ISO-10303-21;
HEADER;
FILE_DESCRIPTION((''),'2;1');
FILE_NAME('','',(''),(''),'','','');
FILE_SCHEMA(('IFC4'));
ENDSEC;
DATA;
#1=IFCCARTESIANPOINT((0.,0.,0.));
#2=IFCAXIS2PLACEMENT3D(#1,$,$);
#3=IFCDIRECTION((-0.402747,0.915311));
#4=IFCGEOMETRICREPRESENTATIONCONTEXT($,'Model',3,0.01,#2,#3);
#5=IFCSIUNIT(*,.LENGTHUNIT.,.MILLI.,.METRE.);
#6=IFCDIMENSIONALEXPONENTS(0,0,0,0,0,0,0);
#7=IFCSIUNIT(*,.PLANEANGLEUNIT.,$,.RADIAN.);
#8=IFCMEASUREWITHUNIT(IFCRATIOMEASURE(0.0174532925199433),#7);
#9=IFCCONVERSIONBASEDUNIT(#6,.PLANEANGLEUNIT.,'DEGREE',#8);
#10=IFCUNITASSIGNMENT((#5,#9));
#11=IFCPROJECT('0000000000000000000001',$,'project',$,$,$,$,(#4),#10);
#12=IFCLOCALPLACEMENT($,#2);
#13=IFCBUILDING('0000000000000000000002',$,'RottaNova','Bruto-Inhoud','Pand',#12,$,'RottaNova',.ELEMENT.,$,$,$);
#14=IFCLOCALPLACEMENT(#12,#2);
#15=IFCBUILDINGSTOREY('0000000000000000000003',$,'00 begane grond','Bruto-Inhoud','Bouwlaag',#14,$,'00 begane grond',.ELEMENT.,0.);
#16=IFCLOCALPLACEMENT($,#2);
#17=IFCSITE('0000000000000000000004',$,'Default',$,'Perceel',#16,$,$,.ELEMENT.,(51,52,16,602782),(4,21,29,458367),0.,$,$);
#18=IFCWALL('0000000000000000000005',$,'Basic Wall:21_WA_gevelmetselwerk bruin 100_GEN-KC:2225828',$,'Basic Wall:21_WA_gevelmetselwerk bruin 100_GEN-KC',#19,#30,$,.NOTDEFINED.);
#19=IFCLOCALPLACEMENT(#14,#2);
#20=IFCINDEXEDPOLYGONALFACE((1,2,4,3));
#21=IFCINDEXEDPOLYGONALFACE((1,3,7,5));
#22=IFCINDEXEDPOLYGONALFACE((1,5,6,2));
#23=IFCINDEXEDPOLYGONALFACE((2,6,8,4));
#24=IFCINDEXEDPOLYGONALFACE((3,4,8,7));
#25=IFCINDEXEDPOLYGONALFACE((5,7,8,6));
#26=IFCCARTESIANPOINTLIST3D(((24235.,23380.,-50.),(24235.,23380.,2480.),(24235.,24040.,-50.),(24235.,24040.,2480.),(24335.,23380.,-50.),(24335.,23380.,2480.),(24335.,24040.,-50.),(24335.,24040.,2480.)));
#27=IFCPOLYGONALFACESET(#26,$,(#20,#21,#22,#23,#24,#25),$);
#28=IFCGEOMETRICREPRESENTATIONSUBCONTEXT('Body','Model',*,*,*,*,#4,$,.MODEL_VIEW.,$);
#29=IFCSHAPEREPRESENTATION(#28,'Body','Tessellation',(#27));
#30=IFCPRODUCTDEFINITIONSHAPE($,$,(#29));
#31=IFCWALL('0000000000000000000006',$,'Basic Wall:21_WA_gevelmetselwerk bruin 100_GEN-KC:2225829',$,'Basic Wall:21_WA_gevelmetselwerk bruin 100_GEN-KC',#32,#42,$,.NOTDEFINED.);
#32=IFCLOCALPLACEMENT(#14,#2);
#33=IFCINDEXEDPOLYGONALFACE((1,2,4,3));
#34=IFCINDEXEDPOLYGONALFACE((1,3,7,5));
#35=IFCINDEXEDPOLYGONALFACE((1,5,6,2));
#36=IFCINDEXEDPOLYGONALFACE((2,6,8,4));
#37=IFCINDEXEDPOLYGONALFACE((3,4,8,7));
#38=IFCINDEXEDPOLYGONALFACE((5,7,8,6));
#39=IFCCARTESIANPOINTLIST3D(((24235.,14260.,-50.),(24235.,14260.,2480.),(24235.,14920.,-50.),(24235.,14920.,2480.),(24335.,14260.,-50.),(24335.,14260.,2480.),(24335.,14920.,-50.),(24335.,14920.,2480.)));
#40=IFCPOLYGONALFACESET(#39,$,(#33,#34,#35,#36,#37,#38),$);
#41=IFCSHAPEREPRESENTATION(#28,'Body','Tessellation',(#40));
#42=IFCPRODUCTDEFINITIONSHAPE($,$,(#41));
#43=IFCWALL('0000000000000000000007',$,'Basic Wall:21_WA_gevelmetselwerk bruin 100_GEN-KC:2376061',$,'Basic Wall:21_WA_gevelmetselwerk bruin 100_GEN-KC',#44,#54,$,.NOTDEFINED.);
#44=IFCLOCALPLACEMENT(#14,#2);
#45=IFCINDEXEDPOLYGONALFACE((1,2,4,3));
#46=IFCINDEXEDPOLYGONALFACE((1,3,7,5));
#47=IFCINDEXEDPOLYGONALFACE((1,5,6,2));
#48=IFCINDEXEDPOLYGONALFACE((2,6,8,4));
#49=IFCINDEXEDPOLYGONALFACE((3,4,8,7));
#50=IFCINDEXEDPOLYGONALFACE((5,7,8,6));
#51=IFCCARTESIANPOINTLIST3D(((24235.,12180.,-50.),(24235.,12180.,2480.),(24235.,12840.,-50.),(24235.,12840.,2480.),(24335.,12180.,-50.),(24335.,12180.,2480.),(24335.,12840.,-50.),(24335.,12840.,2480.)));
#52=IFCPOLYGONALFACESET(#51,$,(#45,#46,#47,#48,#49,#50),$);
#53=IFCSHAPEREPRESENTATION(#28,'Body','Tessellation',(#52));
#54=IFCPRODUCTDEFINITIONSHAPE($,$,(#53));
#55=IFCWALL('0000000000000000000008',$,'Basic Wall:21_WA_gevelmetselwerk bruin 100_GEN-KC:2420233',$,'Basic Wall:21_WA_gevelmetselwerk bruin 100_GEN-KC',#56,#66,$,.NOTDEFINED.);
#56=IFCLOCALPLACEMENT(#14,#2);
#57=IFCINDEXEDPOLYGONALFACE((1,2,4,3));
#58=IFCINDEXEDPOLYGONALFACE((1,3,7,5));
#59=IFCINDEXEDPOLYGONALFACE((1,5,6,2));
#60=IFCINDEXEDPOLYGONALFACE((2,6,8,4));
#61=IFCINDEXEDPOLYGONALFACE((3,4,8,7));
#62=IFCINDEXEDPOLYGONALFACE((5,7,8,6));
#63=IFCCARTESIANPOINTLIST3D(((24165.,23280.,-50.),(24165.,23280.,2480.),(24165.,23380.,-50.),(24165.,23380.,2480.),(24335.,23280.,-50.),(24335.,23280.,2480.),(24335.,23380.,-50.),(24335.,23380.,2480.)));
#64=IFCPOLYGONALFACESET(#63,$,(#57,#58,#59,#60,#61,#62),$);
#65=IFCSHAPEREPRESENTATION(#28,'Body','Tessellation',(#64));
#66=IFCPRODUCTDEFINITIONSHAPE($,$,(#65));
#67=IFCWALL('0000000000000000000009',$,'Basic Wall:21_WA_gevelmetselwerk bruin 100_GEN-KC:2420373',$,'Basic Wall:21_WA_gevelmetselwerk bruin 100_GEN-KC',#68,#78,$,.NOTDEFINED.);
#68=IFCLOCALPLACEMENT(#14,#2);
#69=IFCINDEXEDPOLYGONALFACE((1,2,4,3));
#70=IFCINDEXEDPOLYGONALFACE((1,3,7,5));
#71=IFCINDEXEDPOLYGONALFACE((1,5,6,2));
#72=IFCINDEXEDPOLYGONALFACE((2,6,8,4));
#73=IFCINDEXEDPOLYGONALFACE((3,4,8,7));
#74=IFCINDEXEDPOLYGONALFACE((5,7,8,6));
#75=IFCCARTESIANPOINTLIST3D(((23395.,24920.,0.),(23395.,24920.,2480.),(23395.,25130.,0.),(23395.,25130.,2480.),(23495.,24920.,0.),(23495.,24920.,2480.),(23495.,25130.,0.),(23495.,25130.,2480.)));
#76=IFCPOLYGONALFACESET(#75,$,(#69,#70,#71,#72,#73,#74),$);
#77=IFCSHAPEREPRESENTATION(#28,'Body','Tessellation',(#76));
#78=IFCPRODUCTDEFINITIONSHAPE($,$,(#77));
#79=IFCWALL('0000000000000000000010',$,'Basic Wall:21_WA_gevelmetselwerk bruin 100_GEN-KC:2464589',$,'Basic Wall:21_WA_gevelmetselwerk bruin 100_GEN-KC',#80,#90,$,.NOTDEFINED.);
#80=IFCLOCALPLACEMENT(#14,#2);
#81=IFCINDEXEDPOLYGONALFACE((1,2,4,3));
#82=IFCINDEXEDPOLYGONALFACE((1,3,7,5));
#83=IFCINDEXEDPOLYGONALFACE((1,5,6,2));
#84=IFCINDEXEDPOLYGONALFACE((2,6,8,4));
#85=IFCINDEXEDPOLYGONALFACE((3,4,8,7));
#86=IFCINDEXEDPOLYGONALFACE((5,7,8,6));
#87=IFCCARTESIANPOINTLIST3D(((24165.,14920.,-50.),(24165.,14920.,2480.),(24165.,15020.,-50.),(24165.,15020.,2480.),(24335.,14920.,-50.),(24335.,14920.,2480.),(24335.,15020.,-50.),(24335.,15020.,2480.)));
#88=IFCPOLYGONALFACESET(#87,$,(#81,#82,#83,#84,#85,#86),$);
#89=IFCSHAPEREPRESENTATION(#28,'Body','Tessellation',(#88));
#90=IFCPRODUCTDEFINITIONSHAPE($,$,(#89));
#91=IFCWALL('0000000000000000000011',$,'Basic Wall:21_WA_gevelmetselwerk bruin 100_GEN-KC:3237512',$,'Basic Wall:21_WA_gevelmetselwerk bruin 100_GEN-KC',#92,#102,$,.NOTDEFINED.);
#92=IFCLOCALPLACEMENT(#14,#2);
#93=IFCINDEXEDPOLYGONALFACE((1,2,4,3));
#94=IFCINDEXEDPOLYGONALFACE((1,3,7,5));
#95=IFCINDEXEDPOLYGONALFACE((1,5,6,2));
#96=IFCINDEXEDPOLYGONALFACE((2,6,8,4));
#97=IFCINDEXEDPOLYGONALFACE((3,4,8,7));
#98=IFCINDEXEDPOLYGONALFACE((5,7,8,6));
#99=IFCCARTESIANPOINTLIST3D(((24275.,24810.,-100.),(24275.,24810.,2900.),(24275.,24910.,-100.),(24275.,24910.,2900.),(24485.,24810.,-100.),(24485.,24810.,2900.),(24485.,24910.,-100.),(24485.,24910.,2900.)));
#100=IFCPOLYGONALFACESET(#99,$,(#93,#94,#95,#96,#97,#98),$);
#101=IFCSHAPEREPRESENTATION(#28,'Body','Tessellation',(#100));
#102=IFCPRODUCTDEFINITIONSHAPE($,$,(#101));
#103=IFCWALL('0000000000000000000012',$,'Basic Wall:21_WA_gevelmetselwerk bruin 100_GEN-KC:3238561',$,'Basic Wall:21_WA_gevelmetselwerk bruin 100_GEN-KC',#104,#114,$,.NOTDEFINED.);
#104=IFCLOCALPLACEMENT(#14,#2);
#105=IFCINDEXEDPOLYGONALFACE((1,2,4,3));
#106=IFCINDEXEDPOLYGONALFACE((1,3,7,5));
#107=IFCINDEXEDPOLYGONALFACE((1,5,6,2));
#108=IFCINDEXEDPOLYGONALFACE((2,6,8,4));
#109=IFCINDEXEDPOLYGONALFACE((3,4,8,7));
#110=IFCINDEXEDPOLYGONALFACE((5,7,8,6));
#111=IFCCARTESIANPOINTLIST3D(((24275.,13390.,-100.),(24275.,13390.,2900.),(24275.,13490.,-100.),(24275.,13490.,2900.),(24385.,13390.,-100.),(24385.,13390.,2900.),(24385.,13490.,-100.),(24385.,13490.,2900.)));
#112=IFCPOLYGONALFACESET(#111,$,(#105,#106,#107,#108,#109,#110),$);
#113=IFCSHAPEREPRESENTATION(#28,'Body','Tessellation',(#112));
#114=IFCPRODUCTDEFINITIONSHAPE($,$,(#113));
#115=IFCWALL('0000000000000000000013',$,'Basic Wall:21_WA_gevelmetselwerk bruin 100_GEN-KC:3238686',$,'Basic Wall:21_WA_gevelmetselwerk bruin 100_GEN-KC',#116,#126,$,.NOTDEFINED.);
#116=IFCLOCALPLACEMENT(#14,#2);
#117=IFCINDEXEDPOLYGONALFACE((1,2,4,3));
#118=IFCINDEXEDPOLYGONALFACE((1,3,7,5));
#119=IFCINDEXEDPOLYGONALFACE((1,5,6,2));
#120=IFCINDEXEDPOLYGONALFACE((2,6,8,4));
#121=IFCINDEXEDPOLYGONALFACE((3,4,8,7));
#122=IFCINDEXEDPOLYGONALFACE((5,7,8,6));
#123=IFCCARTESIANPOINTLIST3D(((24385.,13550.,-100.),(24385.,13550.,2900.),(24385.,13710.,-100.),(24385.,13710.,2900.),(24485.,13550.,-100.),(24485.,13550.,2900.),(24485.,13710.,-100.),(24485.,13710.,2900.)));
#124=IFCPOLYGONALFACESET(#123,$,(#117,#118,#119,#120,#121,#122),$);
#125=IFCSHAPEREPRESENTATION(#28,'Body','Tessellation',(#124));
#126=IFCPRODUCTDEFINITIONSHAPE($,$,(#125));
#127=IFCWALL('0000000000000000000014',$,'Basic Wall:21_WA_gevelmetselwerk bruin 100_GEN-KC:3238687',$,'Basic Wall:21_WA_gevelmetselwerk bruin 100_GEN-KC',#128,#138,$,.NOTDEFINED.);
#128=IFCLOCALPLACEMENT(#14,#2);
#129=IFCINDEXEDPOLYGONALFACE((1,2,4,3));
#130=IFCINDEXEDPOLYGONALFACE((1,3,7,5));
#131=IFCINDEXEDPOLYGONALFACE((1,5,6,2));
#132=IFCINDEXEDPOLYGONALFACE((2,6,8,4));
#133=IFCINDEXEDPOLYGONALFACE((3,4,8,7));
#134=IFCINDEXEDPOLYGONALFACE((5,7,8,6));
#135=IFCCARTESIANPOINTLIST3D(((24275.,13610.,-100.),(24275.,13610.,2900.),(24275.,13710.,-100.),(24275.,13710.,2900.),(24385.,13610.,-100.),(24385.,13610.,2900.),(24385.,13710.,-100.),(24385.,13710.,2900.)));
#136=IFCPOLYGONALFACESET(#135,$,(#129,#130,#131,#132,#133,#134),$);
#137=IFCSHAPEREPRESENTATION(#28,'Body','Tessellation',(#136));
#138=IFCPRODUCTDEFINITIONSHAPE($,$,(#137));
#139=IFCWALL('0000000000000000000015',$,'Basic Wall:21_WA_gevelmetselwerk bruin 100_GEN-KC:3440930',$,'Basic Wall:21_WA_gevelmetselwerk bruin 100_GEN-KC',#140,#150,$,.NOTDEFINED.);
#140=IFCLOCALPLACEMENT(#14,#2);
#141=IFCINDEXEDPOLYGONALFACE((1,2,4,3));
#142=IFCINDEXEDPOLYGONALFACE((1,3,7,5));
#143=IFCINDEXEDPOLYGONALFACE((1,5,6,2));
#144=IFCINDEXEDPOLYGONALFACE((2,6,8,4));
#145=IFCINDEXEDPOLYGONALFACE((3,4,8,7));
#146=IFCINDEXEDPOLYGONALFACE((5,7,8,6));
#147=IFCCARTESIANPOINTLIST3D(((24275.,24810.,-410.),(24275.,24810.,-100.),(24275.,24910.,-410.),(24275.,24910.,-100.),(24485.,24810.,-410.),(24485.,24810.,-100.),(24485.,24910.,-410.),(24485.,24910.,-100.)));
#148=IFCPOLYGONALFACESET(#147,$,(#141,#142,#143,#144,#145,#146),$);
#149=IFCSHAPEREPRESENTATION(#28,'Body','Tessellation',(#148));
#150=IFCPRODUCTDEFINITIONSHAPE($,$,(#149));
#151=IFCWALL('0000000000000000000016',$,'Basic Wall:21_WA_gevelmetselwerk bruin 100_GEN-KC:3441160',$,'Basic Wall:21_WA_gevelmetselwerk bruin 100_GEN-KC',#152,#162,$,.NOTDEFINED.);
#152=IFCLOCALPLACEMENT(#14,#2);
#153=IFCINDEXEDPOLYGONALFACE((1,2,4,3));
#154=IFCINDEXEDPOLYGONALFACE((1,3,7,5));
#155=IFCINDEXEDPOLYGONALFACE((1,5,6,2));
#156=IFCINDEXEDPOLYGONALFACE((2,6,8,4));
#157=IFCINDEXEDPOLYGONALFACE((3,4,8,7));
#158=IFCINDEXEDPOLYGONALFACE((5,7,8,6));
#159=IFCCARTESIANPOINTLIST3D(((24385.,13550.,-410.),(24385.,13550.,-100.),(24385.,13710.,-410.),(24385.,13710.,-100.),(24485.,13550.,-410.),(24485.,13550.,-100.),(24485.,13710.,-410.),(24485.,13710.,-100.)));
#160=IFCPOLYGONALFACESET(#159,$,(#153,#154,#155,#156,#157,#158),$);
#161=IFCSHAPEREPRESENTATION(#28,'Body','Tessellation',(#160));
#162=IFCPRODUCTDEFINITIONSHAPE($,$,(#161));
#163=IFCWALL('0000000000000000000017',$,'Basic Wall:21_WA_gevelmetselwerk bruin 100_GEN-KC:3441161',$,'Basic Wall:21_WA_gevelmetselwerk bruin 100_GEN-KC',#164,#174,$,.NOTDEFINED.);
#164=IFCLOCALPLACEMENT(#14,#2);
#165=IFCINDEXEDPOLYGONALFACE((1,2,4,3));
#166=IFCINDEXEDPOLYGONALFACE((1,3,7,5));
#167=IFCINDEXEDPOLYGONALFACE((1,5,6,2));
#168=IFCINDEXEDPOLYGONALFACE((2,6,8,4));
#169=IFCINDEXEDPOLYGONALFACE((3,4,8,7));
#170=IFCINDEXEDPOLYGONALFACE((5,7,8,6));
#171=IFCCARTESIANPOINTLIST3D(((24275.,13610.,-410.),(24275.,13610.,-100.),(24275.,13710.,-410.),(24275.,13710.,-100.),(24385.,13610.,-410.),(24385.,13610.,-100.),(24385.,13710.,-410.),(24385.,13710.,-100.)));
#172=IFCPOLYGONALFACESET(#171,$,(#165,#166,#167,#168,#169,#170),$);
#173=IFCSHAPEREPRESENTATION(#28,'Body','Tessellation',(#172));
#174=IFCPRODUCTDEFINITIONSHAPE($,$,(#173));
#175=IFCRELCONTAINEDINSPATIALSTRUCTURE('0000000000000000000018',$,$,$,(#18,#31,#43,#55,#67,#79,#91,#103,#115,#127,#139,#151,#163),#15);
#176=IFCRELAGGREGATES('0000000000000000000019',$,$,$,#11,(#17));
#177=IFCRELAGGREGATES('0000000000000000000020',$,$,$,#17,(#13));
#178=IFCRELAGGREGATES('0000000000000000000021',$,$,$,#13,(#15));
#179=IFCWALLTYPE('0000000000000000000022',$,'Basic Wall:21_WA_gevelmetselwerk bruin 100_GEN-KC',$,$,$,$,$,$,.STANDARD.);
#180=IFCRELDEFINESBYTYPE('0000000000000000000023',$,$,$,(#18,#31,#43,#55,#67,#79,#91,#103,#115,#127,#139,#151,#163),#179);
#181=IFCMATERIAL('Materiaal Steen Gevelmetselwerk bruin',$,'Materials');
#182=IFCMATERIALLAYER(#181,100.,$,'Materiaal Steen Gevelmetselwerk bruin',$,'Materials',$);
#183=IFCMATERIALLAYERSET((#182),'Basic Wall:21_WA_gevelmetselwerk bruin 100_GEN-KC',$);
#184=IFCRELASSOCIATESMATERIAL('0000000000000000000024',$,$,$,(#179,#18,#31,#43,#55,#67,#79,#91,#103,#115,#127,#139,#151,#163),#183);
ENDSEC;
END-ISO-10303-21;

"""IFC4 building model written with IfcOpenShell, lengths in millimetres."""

from ifc_helpers import new_model, entity, si_unit, converted_unit, direction, frame, frame_2d, origin, place, context, subcontext, project, spatial, rectangle, extrude, material, layer, layer_set, type_object, element, save


model = new_model("IFC4")

# Units and contexts
model_context = context("Model", 3, precision=0.01, world=origin(), true_north=direction((-0.402747, 0.915311)))
body_context = subcontext(model_context, "Body", "Model", "MODEL_VIEW")
ifc_project = project(units=[si_unit("LENGTHUNIT", "METRE", prefix="MILLI"), converted_unit("PLANEANGLEUNIT", "DEGREE", entity("IfcRatioMeasure", 0.0174532925199433), si_unit("PLANEANGLEUNIT", "RADIAN"), dimensions=[0, 0, 0, 0, 0, 0, 0])], contexts=[model_context])

# Site, building, storey
site_placement = place(None, origin())
site = spatial("IfcSite", under=ifc_project, at=site_placement, Name="Default", ObjectType="Perceel", CompositionType="ELEMENT", RefLatitude=(51, 52, 16, 602782), RefLongitude=(4, 21, 29, 458367), RefElevation=0.0)
building_placement = place(None, origin())
building = spatial("IfcBuilding", under=site, at=building_placement, Name="RottaNova", Description="Bruto-Inhoud", ObjectType="Pand", LongName="RottaNova", CompositionType="ELEMENT")
storey_placement = place(building_placement, origin())
storey = spatial("IfcBuildingStorey", under=building, at=storey_placement, Name="00 begane grond", Description="Bruto-Inhoud", ObjectType="Bouwlaag", LongName="00 begane grond", CompositionType="ELEMENT", Elevation=0.0)

# Walls
ifc_material_1 = material(Name="Materiaal Steen Gevelmetselwerk bruin", Category="Materials")
ifc_layer_1 = layer(ifc_material_1, 100.0, Name="Materiaal Steen Gevelmetselwerk bruin", Category="Materials")
ifc_layer_set_1 = layer_set([ifc_layer_1], Name="Basic Wall:21_WA_gevelmetselwerk bruin 100_GEN-KC")
wall_type_1 = type_object("IfcWallType", Name="Basic Wall:21_WA_gevelmetselwerk bruin 100_GEN-KC", PredefinedType="STANDARD", material=ifc_layer_set_1)
wall_1_placement = place(storey_placement, frame((24285.0, 24040.0, -50.0), z_axis=(0.0, 0.0, 1.0), x_axis=(0.0, -1.0, 0.0)))
element("IfcWall", 1, at=wall_1_placement, inside=storey, type_object=wall_type_1, material=ifc_layer_set_1, Name="Basic Wall:21_WA_gevelmetselwerk bruin 100_GEN-KC:2225828", ObjectType="Basic Wall:21_WA_gevelmetselwerk bruin 100_GEN-KC", PredefinedType="NOTDEFINED", context=body_context, shape_type="SweptSolid", body=[
    extrude(rectangle(XDim=660.0, YDim=100.0, at=frame_2d((330.0, 0.0), x_axis=(-1.0, 0.0))), origin(), (0.0, 0.0, 1.0), 2530.0),
])
wall_2_placement = place(storey_placement, frame((24285.0, 14260.0, -50.0), z_axis=(0.0, 0.0, 1.0), x_axis=(0.0, 1.0, 0.0)))
element("IfcWall", 2, at=wall_2_placement, inside=storey, type_object=wall_type_1, material=ifc_layer_set_1, Name="Basic Wall:21_WA_gevelmetselwerk bruin 100_GEN-KC:2225829", ObjectType="Basic Wall:21_WA_gevelmetselwerk bruin 100_GEN-KC", PredefinedType="NOTDEFINED", context=body_context, shape_type="SweptSolid", body=[
    extrude(rectangle(XDim=660.0, YDim=100.0, at=frame_2d((330.0, 0.0), x_axis=(-1.0, 0.0))), origin(), (0.0, 0.0, 1.0), 2530.0),
])
wall_3_placement = place(storey_placement, frame((24285.0, 12840.0, -50.0), z_axis=(0.0, 0.0, 1.0), x_axis=(0.0, -1.0, 0.0)))
element("IfcWall", 3, at=wall_3_placement, inside=storey, type_object=wall_type_1, material=ifc_layer_set_1, Name="Basic Wall:21_WA_gevelmetselwerk bruin 100_GEN-KC:2376061", ObjectType="Basic Wall:21_WA_gevelmetselwerk bruin 100_GEN-KC", PredefinedType="NOTDEFINED", context=body_context, shape_type="SweptSolid", body=[
    extrude(rectangle(XDim=660.0, YDim=100.0, at=frame_2d((330.0, 0.0), x_axis=(-1.0, 0.0))), origin(), (0.0, 0.0, 1.0), 2530.0),
])
wall_4_placement = place(storey_placement, frame((24335.0, 23330.0, -50.0), z_axis=(0.0, 0.0, 1.0), x_axis=(-1.0, 0.0, 0.0)))
element("IfcWall", 4, at=wall_4_placement, inside=storey, type_object=wall_type_1, material=ifc_layer_set_1, Name="Basic Wall:21_WA_gevelmetselwerk bruin 100_GEN-KC:2420233", ObjectType="Basic Wall:21_WA_gevelmetselwerk bruin 100_GEN-KC", PredefinedType="NOTDEFINED", context=body_context, shape_type="SweptSolid", body=[
    extrude(rectangle(XDim=170.0, YDim=100.0, at=frame_2d((85.0, 0.0), x_axis=(-1.0, 0.0))), origin(), (0.0, 0.0, 1.0), 2530.0),
])
wall_5_placement = place(storey_placement, frame((23445.0, 24920.0, 0.0), z_axis=(0.0, 0.0, 1.0), x_axis=(0.0, 1.0, 0.0)))
element("IfcWall", 5, at=wall_5_placement, inside=storey, type_object=wall_type_1, material=ifc_layer_set_1, Name="Basic Wall:21_WA_gevelmetselwerk bruin 100_GEN-KC:2420373", ObjectType="Basic Wall:21_WA_gevelmetselwerk bruin 100_GEN-KC", PredefinedType="NOTDEFINED", context=body_context, shape_type="SweptSolid", body=[
    extrude(rectangle(XDim=210.0, YDim=100.0, at=frame_2d((105.0, 0.0), x_axis=(-1.0, 0.0))), origin(), (0.0, 0.0, 1.0), 2480.0),
])
wall_6_placement = place(storey_placement, frame((24335.0, 14970.0, -50.0), z_axis=(0.0, 0.0, 1.0), x_axis=(-1.0, 0.0, 0.0)))
element("IfcWall", 6, at=wall_6_placement, inside=storey, type_object=wall_type_1, material=ifc_layer_set_1, Name="Basic Wall:21_WA_gevelmetselwerk bruin 100_GEN-KC:2464589", ObjectType="Basic Wall:21_WA_gevelmetselwerk bruin 100_GEN-KC", PredefinedType="NOTDEFINED", context=body_context, shape_type="SweptSolid", body=[
    extrude(rectangle(XDim=170.0, YDim=100.0, at=frame_2d((85.0, 0.0), x_axis=(-1.0, 0.0))), origin(), (0.0, 0.0, 1.0), 2530.0),
])
wall_7_placement = place(storey_placement, frame((24485.0, 24860.0, -100.0), z_axis=(0.0, 0.0, 1.0), x_axis=(-1.0, 0.0, 0.0)))
element("IfcWall", 7, at=wall_7_placement, inside=storey, type_object=wall_type_1, material=ifc_layer_set_1, Name="Basic Wall:21_WA_gevelmetselwerk bruin 100_GEN-KC:3237512", ObjectType="Basic Wall:21_WA_gevelmetselwerk bruin 100_GEN-KC", PredefinedType="NOTDEFINED", context=body_context, shape_type="SweptSolid", body=[
    extrude(rectangle(XDim=210.0, YDim=100.0, at=frame_2d((105.0, 0.0), x_axis=(-1.0, 0.0))), origin(), (0.0, 0.0, 1.0), 3000.0),
])
wall_8_placement = place(storey_placement, frame((24385.0, 13440.0, -100.0), z_axis=(0.0, 0.0, 1.0), x_axis=(-1.0, 0.0, 0.0)))
element("IfcWall", 8, at=wall_8_placement, inside=storey, type_object=wall_type_1, material=ifc_layer_set_1, Name="Basic Wall:21_WA_gevelmetselwerk bruin 100_GEN-KC:3238561", ObjectType="Basic Wall:21_WA_gevelmetselwerk bruin 100_GEN-KC", PredefinedType="NOTDEFINED", context=body_context, shape_type="SweptSolid", body=[
    extrude(rectangle(XDim=110.0, YDim=100.0, at=frame_2d((55.0, 0.0), x_axis=(-1.0, 0.0))), origin(), (0.0, 0.0, 1.0), 3000.0),
])
wall_9_placement = place(storey_placement, frame((24435.0, 13550.0, -100.0), z_axis=(0.0, 0.0, 1.0), x_axis=(0.0, 1.0, 0.0)))
element("IfcWall", 9, at=wall_9_placement, inside=storey, type_object=wall_type_1, material=ifc_layer_set_1, Name="Basic Wall:21_WA_gevelmetselwerk bruin 100_GEN-KC:3238686", ObjectType="Basic Wall:21_WA_gevelmetselwerk bruin 100_GEN-KC", PredefinedType="NOTDEFINED", context=body_context, shape_type="SweptSolid", body=[
    extrude(rectangle(XDim=160.0, YDim=100.0, at=frame_2d((80.0, 0.0), x_axis=(-1.0, 0.0))), origin(), (0.0, 0.0, 1.0), 3000.0),
])
wall_10_placement = place(storey_placement, frame((24385.0, 13660.0, -100.0), z_axis=(0.0, 0.0, 1.0), x_axis=(-1.0, 0.0, 0.0)))
element("IfcWall", 10, at=wall_10_placement, inside=storey, type_object=wall_type_1, material=ifc_layer_set_1, Name="Basic Wall:21_WA_gevelmetselwerk bruin 100_GEN-KC:3238687", ObjectType="Basic Wall:21_WA_gevelmetselwerk bruin 100_GEN-KC", PredefinedType="NOTDEFINED", context=body_context, shape_type="SweptSolid", body=[
    extrude(rectangle(XDim=110.0, YDim=100.0, at=frame_2d((55.0, 0.0), x_axis=(-1.0, 0.0))), origin(), (0.0, 0.0, 1.0), 3000.0),
])
wall_11_placement = place(storey_placement, frame((24485.0, 24860.0, -410.0), z_axis=(0.0, 0.0, 1.0), x_axis=(-1.0, 0.0, 0.0)))
element("IfcWall", 11, at=wall_11_placement, inside=storey, type_object=wall_type_1, material=ifc_layer_set_1, Name="Basic Wall:21_WA_gevelmetselwerk bruin 100_GEN-KC:3440930", ObjectType="Basic Wall:21_WA_gevelmetselwerk bruin 100_GEN-KC", PredefinedType="NOTDEFINED", context=body_context, shape_type="SweptSolid", body=[
    extrude(rectangle(XDim=210.0, YDim=100.0, at=frame_2d((105.0, 0.0), x_axis=(-1.0, 0.0))), origin(), (0.0, 0.0, 1.0), 310.0),
])
wall_12_placement = place(storey_placement, frame((24435.0, 13550.0, -410.0), z_axis=(0.0, 0.0, 1.0), x_axis=(0.0, 1.0, 0.0)))
element("IfcWall", 12, at=wall_12_placement, inside=storey, type_object=wall_type_1, material=ifc_layer_set_1, Name="Basic Wall:21_WA_gevelmetselwerk bruin 100_GEN-KC:3441160", ObjectType="Basic Wall:21_WA_gevelmetselwerk bruin 100_GEN-KC", PredefinedType="NOTDEFINED", context=body_context, shape_type="SweptSolid", body=[
    extrude(rectangle(XDim=160.0, YDim=100.0, at=frame_2d((80.0, 0.0), x_axis=(-1.0, 0.0))), origin(), (0.0, 0.0, 1.0), 310.0),
])
wall_13_placement = place(storey_placement, frame((24385.0, 13660.0, -410.0), z_axis=(0.0, 0.0, 1.0), x_axis=(-1.0, 0.0, 0.0)))
element("IfcWall", 13, at=wall_13_placement, inside=storey, type_object=wall_type_1, material=ifc_layer_set_1, Name="Basic Wall:21_WA_gevelmetselwerk bruin 100_GEN-KC:3441161", ObjectType="Basic Wall:21_WA_gevelmetselwerk bruin 100_GEN-KC", PredefinedType="NOTDEFINED", context=body_context, shape_type="SweptSolid", body=[
    extrude(rectangle(XDim=110.0, YDim=100.0, at=frame_2d((55.0, 0.0), x_axis=(-1.0, 0.0))), origin(), (0.0, 0.0, 1.0), 310.0),
])

save(model, "model.ifc")
